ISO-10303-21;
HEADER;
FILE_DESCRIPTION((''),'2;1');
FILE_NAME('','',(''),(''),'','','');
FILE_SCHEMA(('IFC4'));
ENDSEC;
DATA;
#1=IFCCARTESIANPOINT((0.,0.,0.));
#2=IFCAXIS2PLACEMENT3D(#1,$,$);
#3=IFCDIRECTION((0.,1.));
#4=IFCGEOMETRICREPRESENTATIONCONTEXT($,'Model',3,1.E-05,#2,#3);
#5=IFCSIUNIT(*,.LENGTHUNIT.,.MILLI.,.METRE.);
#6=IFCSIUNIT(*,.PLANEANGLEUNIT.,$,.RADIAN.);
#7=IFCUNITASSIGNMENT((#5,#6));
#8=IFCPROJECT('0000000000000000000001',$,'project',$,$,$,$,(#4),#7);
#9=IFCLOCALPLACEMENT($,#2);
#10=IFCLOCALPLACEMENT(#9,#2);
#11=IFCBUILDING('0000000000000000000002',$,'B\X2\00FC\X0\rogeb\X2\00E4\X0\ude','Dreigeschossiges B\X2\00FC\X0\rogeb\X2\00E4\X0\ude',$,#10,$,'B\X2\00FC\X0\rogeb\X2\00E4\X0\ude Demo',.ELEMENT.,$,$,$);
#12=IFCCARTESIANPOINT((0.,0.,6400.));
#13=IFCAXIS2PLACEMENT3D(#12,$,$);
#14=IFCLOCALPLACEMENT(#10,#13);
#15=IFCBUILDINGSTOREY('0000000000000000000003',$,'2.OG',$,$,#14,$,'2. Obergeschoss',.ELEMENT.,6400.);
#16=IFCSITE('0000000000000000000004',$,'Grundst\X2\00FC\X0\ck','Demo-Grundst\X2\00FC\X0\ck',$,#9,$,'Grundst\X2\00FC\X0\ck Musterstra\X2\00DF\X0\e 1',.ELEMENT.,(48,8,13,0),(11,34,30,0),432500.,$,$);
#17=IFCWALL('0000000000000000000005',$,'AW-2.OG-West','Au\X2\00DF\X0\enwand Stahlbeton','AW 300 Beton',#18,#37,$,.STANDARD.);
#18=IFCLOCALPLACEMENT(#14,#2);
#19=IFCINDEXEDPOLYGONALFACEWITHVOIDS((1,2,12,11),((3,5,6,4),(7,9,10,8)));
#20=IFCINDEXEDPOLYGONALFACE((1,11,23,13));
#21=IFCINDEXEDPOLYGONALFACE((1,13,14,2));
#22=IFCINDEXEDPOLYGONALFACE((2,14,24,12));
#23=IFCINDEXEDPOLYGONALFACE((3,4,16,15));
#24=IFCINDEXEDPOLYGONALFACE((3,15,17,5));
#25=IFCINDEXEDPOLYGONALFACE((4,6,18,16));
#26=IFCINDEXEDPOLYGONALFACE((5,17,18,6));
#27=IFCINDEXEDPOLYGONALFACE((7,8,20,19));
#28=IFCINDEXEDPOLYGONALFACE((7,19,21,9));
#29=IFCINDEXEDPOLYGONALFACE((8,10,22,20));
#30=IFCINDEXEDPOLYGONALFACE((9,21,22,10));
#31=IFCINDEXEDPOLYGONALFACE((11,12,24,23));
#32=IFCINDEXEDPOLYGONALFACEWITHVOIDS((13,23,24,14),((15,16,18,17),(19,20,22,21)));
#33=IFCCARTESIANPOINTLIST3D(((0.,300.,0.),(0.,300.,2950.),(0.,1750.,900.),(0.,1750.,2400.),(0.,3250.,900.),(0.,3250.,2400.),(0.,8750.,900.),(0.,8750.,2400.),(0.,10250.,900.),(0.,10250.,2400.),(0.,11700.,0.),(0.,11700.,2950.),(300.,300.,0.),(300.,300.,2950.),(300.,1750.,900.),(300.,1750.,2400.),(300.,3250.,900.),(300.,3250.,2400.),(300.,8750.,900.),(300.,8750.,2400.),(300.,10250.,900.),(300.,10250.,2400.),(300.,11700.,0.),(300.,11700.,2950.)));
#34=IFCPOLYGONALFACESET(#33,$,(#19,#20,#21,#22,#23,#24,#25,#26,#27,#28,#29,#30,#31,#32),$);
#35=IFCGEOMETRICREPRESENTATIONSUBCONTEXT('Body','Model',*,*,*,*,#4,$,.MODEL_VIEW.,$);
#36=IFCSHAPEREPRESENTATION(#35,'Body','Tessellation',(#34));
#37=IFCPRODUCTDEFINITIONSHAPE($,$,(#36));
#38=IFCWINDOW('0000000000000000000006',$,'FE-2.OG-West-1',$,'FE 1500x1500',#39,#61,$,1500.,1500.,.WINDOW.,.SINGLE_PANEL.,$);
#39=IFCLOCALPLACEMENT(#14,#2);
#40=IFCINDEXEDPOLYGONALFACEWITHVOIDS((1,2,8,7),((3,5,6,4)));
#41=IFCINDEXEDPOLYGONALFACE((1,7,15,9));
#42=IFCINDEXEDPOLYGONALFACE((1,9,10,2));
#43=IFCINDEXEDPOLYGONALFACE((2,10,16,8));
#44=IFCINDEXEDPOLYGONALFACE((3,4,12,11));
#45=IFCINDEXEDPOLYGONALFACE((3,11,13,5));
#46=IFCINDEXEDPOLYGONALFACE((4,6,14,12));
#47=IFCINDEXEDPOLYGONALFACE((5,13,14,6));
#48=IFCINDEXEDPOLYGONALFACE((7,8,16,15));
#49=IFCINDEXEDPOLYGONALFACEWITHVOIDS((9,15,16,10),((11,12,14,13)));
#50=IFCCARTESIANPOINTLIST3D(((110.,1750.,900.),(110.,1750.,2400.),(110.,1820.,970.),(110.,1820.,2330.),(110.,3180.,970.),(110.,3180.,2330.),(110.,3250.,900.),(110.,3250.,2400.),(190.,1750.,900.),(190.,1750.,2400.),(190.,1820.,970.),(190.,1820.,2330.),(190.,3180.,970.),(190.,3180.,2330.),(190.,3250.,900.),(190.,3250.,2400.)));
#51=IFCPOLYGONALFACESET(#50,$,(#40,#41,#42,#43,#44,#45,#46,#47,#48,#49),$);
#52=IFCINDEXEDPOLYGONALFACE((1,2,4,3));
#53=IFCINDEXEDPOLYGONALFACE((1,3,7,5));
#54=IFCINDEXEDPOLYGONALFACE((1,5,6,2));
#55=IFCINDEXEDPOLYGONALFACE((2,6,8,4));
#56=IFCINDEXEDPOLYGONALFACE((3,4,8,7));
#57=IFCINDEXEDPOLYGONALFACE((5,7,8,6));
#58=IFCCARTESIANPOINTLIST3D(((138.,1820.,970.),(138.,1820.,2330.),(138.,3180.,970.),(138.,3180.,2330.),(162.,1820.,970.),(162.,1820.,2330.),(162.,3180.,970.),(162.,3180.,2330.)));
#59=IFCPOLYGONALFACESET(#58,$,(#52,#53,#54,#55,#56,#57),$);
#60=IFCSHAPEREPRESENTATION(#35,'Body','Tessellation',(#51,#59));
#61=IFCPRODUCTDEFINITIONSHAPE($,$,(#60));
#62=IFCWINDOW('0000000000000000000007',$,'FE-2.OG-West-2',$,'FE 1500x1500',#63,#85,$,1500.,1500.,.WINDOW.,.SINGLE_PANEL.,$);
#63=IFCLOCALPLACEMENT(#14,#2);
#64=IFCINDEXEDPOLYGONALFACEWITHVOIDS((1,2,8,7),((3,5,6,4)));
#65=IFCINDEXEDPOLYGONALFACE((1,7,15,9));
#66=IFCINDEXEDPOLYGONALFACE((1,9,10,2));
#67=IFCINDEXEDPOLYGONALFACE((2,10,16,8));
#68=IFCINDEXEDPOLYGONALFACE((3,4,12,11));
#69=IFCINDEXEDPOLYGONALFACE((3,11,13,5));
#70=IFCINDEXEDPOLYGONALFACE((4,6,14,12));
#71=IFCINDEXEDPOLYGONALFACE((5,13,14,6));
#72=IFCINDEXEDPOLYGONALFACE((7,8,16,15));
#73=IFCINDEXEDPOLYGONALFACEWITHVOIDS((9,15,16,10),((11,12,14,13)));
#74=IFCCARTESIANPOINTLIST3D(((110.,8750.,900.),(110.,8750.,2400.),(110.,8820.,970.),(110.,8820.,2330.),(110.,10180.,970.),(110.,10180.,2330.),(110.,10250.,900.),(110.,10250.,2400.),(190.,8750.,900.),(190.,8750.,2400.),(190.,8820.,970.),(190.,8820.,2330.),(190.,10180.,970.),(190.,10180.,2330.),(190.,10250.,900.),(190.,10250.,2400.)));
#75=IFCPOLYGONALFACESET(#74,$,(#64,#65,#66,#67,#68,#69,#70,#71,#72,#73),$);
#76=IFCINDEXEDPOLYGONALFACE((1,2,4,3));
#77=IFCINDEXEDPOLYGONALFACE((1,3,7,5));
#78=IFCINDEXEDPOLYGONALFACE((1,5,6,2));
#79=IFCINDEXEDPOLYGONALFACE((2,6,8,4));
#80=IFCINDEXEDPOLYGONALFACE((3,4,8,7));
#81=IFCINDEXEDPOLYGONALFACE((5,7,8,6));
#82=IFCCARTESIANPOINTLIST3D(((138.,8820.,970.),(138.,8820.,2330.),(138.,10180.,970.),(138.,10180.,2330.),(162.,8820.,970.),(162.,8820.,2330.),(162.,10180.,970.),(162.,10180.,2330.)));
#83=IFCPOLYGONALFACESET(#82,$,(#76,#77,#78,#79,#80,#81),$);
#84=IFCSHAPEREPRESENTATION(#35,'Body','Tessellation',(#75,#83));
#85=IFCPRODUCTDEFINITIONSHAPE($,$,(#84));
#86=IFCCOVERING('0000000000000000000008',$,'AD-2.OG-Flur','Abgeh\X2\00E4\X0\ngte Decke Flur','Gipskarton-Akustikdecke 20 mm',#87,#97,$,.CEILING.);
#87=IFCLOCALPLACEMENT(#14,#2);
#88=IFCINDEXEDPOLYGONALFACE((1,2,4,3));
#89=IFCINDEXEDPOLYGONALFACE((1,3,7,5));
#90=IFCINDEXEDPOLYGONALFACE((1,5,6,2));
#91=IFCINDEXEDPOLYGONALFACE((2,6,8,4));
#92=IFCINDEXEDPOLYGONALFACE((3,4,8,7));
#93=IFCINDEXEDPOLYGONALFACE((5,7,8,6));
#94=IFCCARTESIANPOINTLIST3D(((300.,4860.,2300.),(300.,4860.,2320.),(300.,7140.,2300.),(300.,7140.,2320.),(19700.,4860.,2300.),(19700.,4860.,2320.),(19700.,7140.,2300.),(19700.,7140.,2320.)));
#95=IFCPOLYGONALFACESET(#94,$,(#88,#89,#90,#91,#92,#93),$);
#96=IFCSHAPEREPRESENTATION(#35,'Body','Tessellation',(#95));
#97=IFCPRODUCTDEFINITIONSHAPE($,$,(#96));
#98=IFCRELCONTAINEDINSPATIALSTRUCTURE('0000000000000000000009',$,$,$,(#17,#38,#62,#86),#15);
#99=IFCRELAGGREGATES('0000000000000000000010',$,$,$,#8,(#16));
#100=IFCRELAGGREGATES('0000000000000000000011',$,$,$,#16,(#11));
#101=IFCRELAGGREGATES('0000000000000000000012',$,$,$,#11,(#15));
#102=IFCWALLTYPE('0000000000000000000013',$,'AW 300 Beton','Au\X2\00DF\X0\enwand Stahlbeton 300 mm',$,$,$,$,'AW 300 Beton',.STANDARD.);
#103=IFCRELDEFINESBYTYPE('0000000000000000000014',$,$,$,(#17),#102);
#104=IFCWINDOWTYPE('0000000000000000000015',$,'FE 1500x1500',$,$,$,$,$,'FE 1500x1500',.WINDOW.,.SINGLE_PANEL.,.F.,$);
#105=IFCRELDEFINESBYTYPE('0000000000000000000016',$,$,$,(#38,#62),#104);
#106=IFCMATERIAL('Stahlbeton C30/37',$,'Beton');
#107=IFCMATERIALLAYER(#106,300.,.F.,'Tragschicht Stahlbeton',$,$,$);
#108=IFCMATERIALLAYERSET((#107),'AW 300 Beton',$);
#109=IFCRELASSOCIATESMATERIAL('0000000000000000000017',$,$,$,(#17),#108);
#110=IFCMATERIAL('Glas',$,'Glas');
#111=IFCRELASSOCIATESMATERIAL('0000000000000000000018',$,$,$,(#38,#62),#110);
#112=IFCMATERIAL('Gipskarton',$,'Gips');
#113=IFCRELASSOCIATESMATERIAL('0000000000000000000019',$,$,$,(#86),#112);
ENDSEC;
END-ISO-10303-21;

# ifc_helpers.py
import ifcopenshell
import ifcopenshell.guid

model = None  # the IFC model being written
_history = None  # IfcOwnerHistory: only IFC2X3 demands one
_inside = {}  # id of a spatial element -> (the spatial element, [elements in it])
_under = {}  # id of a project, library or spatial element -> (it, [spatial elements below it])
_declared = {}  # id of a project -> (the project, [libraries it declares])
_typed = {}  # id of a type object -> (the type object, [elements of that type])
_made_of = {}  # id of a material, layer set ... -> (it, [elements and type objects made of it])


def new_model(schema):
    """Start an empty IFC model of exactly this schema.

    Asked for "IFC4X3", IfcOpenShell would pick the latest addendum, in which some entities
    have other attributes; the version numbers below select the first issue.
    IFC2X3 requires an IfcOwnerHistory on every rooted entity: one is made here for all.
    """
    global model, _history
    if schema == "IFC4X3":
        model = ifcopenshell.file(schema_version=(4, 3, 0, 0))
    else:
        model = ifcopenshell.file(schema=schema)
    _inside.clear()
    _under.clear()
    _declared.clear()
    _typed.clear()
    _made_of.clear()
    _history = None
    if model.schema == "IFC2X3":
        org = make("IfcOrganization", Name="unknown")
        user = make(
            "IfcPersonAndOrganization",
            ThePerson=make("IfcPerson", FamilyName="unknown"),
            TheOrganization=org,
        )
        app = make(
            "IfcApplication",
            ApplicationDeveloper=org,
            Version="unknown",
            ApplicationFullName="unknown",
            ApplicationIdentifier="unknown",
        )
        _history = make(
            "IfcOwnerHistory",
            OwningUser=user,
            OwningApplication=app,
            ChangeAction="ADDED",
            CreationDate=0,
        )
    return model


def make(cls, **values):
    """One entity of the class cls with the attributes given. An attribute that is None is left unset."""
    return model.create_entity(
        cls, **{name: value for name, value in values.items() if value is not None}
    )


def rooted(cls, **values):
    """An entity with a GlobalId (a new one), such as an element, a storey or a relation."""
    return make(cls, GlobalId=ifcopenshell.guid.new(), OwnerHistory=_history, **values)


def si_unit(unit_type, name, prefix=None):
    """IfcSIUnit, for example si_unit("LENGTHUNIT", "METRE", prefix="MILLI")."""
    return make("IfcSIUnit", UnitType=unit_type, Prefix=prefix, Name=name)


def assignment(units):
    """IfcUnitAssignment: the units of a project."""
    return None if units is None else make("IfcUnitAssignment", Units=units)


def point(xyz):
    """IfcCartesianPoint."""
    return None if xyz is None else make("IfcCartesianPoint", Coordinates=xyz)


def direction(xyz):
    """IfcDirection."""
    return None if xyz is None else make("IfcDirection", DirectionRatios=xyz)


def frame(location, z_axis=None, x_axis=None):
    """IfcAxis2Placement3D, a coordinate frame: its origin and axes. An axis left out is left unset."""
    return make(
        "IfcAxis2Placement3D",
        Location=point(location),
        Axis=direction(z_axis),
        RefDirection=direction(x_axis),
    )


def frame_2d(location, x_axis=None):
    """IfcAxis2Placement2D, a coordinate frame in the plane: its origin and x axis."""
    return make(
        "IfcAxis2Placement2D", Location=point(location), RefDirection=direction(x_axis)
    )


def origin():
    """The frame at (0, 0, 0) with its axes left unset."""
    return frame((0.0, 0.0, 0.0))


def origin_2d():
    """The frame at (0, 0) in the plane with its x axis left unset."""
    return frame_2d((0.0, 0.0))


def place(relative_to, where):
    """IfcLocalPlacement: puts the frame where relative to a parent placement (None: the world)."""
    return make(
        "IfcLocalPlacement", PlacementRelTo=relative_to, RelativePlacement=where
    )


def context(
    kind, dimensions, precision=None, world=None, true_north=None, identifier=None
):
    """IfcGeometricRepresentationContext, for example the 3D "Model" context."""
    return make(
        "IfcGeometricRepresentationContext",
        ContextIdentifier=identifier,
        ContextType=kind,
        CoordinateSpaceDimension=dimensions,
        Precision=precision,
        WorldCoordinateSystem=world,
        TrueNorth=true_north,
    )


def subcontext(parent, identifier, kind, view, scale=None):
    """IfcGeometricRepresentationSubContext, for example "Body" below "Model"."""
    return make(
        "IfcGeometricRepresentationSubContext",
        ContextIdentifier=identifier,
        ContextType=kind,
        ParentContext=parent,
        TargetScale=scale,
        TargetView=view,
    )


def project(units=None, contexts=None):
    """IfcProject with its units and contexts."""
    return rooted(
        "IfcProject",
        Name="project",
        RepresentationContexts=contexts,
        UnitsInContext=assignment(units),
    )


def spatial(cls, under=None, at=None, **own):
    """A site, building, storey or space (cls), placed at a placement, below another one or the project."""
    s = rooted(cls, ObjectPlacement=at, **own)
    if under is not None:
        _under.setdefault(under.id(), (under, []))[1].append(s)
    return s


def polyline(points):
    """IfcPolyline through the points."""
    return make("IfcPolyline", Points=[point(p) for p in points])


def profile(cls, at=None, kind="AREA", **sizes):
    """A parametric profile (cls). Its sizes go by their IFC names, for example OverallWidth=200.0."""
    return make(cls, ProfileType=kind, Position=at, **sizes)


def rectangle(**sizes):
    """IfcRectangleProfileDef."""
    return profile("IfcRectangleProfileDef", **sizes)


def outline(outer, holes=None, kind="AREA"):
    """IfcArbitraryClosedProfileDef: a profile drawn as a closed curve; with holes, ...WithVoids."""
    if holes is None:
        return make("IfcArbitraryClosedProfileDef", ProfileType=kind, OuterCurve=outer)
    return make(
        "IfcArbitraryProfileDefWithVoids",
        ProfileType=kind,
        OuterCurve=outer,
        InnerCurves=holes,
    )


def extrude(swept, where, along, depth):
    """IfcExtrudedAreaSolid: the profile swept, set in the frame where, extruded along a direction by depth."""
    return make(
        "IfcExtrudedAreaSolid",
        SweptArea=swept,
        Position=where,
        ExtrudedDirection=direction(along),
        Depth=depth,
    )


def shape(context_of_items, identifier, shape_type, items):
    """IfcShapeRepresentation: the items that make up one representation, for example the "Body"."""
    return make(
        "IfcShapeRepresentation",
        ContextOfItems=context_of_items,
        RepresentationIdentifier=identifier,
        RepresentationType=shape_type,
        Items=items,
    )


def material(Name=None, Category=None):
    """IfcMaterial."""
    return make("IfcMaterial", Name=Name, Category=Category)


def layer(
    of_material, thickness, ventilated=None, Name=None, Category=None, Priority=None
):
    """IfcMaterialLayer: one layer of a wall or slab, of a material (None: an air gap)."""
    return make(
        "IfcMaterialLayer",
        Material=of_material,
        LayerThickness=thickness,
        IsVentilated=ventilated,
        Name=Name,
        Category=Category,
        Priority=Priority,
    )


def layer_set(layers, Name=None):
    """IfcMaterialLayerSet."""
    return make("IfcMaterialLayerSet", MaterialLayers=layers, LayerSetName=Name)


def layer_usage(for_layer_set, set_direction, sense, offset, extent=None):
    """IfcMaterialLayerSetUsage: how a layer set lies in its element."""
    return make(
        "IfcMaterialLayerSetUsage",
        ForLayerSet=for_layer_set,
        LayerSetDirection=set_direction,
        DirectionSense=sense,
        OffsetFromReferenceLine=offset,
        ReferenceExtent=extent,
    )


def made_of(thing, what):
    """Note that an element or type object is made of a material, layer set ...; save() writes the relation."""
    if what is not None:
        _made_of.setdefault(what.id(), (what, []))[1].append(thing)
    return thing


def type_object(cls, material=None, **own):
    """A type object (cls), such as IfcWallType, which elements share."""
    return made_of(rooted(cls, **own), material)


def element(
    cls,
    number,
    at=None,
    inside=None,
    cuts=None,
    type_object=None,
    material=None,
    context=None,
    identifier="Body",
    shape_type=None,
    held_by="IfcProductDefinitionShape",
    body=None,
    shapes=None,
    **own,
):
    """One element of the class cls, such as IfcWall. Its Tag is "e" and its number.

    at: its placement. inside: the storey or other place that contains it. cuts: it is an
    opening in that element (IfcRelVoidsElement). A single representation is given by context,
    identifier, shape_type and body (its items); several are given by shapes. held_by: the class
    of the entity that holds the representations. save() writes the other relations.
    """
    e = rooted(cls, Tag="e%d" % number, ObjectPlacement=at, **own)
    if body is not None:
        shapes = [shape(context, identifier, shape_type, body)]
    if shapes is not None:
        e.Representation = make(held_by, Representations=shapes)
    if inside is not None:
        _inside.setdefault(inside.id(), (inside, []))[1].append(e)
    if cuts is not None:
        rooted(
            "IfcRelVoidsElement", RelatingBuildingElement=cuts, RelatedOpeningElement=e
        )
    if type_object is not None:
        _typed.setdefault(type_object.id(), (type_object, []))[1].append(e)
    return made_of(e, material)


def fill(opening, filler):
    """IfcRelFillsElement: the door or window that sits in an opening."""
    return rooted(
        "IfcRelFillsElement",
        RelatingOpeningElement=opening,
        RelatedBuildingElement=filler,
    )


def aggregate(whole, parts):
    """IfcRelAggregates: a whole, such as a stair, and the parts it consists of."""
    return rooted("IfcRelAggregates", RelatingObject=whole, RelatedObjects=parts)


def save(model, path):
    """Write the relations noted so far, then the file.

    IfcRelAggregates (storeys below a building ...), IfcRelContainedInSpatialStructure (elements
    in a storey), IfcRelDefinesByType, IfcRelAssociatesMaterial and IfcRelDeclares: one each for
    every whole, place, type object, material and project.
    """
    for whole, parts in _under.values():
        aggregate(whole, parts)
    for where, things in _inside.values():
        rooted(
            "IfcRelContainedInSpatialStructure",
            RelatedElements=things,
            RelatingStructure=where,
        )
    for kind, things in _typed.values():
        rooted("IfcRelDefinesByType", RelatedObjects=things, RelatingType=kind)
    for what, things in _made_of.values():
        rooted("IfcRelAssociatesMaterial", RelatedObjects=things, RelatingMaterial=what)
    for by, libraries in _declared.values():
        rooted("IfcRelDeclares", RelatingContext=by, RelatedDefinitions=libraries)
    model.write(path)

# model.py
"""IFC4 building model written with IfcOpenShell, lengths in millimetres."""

from ifc_helpers import new_model, si_unit, direction, frame, frame_2d, origin, origin_2d, place, context, subcontext, project, spatial, polyline, rectangle, outline, extrude, material, layer, layer_set, layer_usage, type_object, element, fill, save


model = new_model("IFC4")

# Units and contexts
model_context = context("Model", 3, precision=1e-05, world=origin(), true_north=direction((0.0, 1.0)))
body_context = subcontext(model_context, "Body", "Model", "MODEL_VIEW")
ifc_project = project(units=[si_unit("LENGTHUNIT", "METRE", prefix="MILLI"), si_unit("PLANEANGLEUNIT", "RADIAN")], contexts=[model_context])

# Site, building, storey
site_placement = place(None, origin())
site = spatial("IfcSite", under=ifc_project, at=site_placement, Name="Grundstück", Description="Demo-Grundstück", LongName="Grundstück Musterstraße 1", CompositionType="ELEMENT", RefLatitude=(48, 8, 13, 0), RefLongitude=(11, 34, 30, 0), RefElevation=432500.0)
building_placement = place(site_placement, origin())
building = spatial("IfcBuilding", under=site, at=building_placement, Name="Bürogebäude", Description="Dreigeschossiges Bürogebäude", LongName="Bürogebäude Demo", CompositionType="ELEMENT")
storey_placement = place(building_placement, frame((0.0, 0.0, 6400.0)))
storey = spatial("IfcBuildingStorey", under=building, at=storey_placement, Name="2.OG", LongName="2. Obergeschoss", CompositionType="ELEMENT", Elevation=6400.0)

# Shared definitions
ifc_material_1 = material(Name="Stahlbeton C30/37", Category="Beton")

# Wall, openings, windows
ifc_layer = layer(ifc_material_1, 300.0, ventilated=False, Name="Tragschicht Stahlbeton")
ifc_layer_set = layer_set([ifc_layer], Name="AW 300 Beton")
ifc_layer_usage = layer_usage(ifc_layer_set, "AXIS2", "POSITIVE", -150.0)
wall_type = type_object("IfcWallType", Name="AW 300 Beton", Description="Außenwand Stahlbeton 300 mm", ElementType="AW 300 Beton", PredefinedType="STANDARD")
ifc_material_2 = material(Name="Glas", Category="Glas")
window_type = type_object("IfcWindowType", Name="FE 1500x1500", ElementType="FE 1500x1500", ParameterTakesPrecedence=False, PartitioningType="SINGLE_PANEL", PredefinedType="WINDOW")
wall_1_placement = place(storey_placement, frame((150.0, 300.0, 0.0), z_axis=(0.0, 0.0, 1.0), x_axis=(0.0, 1.0, 0.0)))
wall_1 = element("IfcWall", 1, at=wall_1_placement, inside=storey, type_object=wall_type, material=ifc_layer_usage, Name="AW-2.OG-West", Description="Außenwand Stahlbeton", ObjectType="AW 300 Beton", PredefinedType="STANDARD", context=body_context, shape_type="SweptSolid", body=[
    extrude(rectangle(XDim=11400.0, YDim=300.0, at=frame_2d((5700.0, 0.0))), origin(), (0.0, 0.0, 1.0), 2950.0),
])
opening_1_placement = place(wall_1_placement, frame((2200.0, 0.0, 900.0)))
opening_1 = element("IfcOpeningElement", 2, at=opening_1_placement, cuts=wall_1, PredefinedType="OPENING", context=body_context, shape_type="SweptSolid", body=[
    extrude(rectangle(XDim=1500.0, YDim=340.0, at=origin_2d()), origin(), (0.0, 0.0, 1.0), 1500.0),
])
opening_2_placement = place(wall_1_placement, frame((9200.0, 0.0, 900.0)))
opening_2 = element("IfcOpeningElement", 3, at=opening_2_placement, cuts=wall_1, PredefinedType="OPENING", context=body_context, shape_type="SweptSolid", body=[
    extrude(rectangle(XDim=1500.0, YDim=340.0, at=origin_2d()), origin(), (0.0, 0.0, 1.0), 1500.0),
])
window_1_placement = place(opening_1_placement, origin())
window_1 = element("IfcWindow", 4, at=window_1_placement, inside=storey, type_object=window_type, material=ifc_material_2, Name="FE-2.OG-West-1", ObjectType="FE 1500x1500", OverallHeight=1500.0, OverallWidth=1500.0, PartitioningType="SINGLE_PANEL", PredefinedType="WINDOW", context=body_context, shape_type="SweptSolid", body=[
    extrude(outline(polyline([(-750.0, 0.0), (750.0, 0.0), (750.0, 1500.0), (-750.0, 1500.0), (-750.0, 0.0)]), holes=[polyline([(-680.0, 70.0), (680.0, 70.0), (680.0, 1430.0), (-680.0, 1430.0), (-680.0, 70.0)])]), frame((0.0, 40.0, 0.0), z_axis=(0.0, -1.0, 0.0), x_axis=(1.0, 0.0, 0.0)), (0.0, 0.0, 1.0), 80.0),
    extrude(rectangle(XDim=1360.0, YDim=24.0, at=origin_2d()), frame((0.0, 0.0, 70.0)), (0.0, 0.0, 1.0), 1360.0),
])
fill(opening_1, window_1)
window_2_placement = place(opening_2_placement, origin())
window_2 = element("IfcWindow", 5, at=window_2_placement, inside=storey, type_object=window_type, material=ifc_material_2, Name="FE-2.OG-West-2", ObjectType="FE 1500x1500", OverallHeight=1500.0, OverallWidth=1500.0, PartitioningType="SINGLE_PANEL", PredefinedType="WINDOW", context=body_context, shape_type="SweptSolid", body=[
    extrude(outline(polyline([(-750.0, 0.0), (750.0, 0.0), (750.0, 1500.0), (-750.0, 1500.0), (-750.0, 0.0)]), holes=[polyline([(-680.0, 70.0), (680.0, 70.0), (680.0, 1430.0), (-680.0, 1430.0), (-680.0, 70.0)])]), frame((0.0, 40.0, 0.0), z_axis=(0.0, -1.0, 0.0), x_axis=(1.0, 0.0, 0.0)), (0.0, 0.0, 1.0), 80.0),
    extrude(rectangle(XDim=1360.0, YDim=24.0, at=origin_2d()), frame((0.0, 0.0, 70.0)), (0.0, 0.0, 1.0), 1360.0),
])
fill(opening_2, window_2)

# Covering
ifc_material_3 = material(Name="Gipskarton", Category="Gips")
covering_placement = place(storey_placement, origin())
element("IfcCovering", 6, at=covering_placement, inside=storey, material=ifc_material_3, Name="AD-2.OG-Flur", Description="Abgehängte Decke Flur", ObjectType="Gipskarton-Akustikdecke 20 mm", PredefinedType="CEILING", context=body_context, shape_type="SweptSolid", body=[
    extrude(rectangle(XDim=19400.0, YDim=2280.0, at=frame_2d((10000.0, 6000.0))), frame((0.0, 0.0, 2300.0)), (0.0, 0.0, 1.0), 20.0),
])

save(model, "model.ifc")
